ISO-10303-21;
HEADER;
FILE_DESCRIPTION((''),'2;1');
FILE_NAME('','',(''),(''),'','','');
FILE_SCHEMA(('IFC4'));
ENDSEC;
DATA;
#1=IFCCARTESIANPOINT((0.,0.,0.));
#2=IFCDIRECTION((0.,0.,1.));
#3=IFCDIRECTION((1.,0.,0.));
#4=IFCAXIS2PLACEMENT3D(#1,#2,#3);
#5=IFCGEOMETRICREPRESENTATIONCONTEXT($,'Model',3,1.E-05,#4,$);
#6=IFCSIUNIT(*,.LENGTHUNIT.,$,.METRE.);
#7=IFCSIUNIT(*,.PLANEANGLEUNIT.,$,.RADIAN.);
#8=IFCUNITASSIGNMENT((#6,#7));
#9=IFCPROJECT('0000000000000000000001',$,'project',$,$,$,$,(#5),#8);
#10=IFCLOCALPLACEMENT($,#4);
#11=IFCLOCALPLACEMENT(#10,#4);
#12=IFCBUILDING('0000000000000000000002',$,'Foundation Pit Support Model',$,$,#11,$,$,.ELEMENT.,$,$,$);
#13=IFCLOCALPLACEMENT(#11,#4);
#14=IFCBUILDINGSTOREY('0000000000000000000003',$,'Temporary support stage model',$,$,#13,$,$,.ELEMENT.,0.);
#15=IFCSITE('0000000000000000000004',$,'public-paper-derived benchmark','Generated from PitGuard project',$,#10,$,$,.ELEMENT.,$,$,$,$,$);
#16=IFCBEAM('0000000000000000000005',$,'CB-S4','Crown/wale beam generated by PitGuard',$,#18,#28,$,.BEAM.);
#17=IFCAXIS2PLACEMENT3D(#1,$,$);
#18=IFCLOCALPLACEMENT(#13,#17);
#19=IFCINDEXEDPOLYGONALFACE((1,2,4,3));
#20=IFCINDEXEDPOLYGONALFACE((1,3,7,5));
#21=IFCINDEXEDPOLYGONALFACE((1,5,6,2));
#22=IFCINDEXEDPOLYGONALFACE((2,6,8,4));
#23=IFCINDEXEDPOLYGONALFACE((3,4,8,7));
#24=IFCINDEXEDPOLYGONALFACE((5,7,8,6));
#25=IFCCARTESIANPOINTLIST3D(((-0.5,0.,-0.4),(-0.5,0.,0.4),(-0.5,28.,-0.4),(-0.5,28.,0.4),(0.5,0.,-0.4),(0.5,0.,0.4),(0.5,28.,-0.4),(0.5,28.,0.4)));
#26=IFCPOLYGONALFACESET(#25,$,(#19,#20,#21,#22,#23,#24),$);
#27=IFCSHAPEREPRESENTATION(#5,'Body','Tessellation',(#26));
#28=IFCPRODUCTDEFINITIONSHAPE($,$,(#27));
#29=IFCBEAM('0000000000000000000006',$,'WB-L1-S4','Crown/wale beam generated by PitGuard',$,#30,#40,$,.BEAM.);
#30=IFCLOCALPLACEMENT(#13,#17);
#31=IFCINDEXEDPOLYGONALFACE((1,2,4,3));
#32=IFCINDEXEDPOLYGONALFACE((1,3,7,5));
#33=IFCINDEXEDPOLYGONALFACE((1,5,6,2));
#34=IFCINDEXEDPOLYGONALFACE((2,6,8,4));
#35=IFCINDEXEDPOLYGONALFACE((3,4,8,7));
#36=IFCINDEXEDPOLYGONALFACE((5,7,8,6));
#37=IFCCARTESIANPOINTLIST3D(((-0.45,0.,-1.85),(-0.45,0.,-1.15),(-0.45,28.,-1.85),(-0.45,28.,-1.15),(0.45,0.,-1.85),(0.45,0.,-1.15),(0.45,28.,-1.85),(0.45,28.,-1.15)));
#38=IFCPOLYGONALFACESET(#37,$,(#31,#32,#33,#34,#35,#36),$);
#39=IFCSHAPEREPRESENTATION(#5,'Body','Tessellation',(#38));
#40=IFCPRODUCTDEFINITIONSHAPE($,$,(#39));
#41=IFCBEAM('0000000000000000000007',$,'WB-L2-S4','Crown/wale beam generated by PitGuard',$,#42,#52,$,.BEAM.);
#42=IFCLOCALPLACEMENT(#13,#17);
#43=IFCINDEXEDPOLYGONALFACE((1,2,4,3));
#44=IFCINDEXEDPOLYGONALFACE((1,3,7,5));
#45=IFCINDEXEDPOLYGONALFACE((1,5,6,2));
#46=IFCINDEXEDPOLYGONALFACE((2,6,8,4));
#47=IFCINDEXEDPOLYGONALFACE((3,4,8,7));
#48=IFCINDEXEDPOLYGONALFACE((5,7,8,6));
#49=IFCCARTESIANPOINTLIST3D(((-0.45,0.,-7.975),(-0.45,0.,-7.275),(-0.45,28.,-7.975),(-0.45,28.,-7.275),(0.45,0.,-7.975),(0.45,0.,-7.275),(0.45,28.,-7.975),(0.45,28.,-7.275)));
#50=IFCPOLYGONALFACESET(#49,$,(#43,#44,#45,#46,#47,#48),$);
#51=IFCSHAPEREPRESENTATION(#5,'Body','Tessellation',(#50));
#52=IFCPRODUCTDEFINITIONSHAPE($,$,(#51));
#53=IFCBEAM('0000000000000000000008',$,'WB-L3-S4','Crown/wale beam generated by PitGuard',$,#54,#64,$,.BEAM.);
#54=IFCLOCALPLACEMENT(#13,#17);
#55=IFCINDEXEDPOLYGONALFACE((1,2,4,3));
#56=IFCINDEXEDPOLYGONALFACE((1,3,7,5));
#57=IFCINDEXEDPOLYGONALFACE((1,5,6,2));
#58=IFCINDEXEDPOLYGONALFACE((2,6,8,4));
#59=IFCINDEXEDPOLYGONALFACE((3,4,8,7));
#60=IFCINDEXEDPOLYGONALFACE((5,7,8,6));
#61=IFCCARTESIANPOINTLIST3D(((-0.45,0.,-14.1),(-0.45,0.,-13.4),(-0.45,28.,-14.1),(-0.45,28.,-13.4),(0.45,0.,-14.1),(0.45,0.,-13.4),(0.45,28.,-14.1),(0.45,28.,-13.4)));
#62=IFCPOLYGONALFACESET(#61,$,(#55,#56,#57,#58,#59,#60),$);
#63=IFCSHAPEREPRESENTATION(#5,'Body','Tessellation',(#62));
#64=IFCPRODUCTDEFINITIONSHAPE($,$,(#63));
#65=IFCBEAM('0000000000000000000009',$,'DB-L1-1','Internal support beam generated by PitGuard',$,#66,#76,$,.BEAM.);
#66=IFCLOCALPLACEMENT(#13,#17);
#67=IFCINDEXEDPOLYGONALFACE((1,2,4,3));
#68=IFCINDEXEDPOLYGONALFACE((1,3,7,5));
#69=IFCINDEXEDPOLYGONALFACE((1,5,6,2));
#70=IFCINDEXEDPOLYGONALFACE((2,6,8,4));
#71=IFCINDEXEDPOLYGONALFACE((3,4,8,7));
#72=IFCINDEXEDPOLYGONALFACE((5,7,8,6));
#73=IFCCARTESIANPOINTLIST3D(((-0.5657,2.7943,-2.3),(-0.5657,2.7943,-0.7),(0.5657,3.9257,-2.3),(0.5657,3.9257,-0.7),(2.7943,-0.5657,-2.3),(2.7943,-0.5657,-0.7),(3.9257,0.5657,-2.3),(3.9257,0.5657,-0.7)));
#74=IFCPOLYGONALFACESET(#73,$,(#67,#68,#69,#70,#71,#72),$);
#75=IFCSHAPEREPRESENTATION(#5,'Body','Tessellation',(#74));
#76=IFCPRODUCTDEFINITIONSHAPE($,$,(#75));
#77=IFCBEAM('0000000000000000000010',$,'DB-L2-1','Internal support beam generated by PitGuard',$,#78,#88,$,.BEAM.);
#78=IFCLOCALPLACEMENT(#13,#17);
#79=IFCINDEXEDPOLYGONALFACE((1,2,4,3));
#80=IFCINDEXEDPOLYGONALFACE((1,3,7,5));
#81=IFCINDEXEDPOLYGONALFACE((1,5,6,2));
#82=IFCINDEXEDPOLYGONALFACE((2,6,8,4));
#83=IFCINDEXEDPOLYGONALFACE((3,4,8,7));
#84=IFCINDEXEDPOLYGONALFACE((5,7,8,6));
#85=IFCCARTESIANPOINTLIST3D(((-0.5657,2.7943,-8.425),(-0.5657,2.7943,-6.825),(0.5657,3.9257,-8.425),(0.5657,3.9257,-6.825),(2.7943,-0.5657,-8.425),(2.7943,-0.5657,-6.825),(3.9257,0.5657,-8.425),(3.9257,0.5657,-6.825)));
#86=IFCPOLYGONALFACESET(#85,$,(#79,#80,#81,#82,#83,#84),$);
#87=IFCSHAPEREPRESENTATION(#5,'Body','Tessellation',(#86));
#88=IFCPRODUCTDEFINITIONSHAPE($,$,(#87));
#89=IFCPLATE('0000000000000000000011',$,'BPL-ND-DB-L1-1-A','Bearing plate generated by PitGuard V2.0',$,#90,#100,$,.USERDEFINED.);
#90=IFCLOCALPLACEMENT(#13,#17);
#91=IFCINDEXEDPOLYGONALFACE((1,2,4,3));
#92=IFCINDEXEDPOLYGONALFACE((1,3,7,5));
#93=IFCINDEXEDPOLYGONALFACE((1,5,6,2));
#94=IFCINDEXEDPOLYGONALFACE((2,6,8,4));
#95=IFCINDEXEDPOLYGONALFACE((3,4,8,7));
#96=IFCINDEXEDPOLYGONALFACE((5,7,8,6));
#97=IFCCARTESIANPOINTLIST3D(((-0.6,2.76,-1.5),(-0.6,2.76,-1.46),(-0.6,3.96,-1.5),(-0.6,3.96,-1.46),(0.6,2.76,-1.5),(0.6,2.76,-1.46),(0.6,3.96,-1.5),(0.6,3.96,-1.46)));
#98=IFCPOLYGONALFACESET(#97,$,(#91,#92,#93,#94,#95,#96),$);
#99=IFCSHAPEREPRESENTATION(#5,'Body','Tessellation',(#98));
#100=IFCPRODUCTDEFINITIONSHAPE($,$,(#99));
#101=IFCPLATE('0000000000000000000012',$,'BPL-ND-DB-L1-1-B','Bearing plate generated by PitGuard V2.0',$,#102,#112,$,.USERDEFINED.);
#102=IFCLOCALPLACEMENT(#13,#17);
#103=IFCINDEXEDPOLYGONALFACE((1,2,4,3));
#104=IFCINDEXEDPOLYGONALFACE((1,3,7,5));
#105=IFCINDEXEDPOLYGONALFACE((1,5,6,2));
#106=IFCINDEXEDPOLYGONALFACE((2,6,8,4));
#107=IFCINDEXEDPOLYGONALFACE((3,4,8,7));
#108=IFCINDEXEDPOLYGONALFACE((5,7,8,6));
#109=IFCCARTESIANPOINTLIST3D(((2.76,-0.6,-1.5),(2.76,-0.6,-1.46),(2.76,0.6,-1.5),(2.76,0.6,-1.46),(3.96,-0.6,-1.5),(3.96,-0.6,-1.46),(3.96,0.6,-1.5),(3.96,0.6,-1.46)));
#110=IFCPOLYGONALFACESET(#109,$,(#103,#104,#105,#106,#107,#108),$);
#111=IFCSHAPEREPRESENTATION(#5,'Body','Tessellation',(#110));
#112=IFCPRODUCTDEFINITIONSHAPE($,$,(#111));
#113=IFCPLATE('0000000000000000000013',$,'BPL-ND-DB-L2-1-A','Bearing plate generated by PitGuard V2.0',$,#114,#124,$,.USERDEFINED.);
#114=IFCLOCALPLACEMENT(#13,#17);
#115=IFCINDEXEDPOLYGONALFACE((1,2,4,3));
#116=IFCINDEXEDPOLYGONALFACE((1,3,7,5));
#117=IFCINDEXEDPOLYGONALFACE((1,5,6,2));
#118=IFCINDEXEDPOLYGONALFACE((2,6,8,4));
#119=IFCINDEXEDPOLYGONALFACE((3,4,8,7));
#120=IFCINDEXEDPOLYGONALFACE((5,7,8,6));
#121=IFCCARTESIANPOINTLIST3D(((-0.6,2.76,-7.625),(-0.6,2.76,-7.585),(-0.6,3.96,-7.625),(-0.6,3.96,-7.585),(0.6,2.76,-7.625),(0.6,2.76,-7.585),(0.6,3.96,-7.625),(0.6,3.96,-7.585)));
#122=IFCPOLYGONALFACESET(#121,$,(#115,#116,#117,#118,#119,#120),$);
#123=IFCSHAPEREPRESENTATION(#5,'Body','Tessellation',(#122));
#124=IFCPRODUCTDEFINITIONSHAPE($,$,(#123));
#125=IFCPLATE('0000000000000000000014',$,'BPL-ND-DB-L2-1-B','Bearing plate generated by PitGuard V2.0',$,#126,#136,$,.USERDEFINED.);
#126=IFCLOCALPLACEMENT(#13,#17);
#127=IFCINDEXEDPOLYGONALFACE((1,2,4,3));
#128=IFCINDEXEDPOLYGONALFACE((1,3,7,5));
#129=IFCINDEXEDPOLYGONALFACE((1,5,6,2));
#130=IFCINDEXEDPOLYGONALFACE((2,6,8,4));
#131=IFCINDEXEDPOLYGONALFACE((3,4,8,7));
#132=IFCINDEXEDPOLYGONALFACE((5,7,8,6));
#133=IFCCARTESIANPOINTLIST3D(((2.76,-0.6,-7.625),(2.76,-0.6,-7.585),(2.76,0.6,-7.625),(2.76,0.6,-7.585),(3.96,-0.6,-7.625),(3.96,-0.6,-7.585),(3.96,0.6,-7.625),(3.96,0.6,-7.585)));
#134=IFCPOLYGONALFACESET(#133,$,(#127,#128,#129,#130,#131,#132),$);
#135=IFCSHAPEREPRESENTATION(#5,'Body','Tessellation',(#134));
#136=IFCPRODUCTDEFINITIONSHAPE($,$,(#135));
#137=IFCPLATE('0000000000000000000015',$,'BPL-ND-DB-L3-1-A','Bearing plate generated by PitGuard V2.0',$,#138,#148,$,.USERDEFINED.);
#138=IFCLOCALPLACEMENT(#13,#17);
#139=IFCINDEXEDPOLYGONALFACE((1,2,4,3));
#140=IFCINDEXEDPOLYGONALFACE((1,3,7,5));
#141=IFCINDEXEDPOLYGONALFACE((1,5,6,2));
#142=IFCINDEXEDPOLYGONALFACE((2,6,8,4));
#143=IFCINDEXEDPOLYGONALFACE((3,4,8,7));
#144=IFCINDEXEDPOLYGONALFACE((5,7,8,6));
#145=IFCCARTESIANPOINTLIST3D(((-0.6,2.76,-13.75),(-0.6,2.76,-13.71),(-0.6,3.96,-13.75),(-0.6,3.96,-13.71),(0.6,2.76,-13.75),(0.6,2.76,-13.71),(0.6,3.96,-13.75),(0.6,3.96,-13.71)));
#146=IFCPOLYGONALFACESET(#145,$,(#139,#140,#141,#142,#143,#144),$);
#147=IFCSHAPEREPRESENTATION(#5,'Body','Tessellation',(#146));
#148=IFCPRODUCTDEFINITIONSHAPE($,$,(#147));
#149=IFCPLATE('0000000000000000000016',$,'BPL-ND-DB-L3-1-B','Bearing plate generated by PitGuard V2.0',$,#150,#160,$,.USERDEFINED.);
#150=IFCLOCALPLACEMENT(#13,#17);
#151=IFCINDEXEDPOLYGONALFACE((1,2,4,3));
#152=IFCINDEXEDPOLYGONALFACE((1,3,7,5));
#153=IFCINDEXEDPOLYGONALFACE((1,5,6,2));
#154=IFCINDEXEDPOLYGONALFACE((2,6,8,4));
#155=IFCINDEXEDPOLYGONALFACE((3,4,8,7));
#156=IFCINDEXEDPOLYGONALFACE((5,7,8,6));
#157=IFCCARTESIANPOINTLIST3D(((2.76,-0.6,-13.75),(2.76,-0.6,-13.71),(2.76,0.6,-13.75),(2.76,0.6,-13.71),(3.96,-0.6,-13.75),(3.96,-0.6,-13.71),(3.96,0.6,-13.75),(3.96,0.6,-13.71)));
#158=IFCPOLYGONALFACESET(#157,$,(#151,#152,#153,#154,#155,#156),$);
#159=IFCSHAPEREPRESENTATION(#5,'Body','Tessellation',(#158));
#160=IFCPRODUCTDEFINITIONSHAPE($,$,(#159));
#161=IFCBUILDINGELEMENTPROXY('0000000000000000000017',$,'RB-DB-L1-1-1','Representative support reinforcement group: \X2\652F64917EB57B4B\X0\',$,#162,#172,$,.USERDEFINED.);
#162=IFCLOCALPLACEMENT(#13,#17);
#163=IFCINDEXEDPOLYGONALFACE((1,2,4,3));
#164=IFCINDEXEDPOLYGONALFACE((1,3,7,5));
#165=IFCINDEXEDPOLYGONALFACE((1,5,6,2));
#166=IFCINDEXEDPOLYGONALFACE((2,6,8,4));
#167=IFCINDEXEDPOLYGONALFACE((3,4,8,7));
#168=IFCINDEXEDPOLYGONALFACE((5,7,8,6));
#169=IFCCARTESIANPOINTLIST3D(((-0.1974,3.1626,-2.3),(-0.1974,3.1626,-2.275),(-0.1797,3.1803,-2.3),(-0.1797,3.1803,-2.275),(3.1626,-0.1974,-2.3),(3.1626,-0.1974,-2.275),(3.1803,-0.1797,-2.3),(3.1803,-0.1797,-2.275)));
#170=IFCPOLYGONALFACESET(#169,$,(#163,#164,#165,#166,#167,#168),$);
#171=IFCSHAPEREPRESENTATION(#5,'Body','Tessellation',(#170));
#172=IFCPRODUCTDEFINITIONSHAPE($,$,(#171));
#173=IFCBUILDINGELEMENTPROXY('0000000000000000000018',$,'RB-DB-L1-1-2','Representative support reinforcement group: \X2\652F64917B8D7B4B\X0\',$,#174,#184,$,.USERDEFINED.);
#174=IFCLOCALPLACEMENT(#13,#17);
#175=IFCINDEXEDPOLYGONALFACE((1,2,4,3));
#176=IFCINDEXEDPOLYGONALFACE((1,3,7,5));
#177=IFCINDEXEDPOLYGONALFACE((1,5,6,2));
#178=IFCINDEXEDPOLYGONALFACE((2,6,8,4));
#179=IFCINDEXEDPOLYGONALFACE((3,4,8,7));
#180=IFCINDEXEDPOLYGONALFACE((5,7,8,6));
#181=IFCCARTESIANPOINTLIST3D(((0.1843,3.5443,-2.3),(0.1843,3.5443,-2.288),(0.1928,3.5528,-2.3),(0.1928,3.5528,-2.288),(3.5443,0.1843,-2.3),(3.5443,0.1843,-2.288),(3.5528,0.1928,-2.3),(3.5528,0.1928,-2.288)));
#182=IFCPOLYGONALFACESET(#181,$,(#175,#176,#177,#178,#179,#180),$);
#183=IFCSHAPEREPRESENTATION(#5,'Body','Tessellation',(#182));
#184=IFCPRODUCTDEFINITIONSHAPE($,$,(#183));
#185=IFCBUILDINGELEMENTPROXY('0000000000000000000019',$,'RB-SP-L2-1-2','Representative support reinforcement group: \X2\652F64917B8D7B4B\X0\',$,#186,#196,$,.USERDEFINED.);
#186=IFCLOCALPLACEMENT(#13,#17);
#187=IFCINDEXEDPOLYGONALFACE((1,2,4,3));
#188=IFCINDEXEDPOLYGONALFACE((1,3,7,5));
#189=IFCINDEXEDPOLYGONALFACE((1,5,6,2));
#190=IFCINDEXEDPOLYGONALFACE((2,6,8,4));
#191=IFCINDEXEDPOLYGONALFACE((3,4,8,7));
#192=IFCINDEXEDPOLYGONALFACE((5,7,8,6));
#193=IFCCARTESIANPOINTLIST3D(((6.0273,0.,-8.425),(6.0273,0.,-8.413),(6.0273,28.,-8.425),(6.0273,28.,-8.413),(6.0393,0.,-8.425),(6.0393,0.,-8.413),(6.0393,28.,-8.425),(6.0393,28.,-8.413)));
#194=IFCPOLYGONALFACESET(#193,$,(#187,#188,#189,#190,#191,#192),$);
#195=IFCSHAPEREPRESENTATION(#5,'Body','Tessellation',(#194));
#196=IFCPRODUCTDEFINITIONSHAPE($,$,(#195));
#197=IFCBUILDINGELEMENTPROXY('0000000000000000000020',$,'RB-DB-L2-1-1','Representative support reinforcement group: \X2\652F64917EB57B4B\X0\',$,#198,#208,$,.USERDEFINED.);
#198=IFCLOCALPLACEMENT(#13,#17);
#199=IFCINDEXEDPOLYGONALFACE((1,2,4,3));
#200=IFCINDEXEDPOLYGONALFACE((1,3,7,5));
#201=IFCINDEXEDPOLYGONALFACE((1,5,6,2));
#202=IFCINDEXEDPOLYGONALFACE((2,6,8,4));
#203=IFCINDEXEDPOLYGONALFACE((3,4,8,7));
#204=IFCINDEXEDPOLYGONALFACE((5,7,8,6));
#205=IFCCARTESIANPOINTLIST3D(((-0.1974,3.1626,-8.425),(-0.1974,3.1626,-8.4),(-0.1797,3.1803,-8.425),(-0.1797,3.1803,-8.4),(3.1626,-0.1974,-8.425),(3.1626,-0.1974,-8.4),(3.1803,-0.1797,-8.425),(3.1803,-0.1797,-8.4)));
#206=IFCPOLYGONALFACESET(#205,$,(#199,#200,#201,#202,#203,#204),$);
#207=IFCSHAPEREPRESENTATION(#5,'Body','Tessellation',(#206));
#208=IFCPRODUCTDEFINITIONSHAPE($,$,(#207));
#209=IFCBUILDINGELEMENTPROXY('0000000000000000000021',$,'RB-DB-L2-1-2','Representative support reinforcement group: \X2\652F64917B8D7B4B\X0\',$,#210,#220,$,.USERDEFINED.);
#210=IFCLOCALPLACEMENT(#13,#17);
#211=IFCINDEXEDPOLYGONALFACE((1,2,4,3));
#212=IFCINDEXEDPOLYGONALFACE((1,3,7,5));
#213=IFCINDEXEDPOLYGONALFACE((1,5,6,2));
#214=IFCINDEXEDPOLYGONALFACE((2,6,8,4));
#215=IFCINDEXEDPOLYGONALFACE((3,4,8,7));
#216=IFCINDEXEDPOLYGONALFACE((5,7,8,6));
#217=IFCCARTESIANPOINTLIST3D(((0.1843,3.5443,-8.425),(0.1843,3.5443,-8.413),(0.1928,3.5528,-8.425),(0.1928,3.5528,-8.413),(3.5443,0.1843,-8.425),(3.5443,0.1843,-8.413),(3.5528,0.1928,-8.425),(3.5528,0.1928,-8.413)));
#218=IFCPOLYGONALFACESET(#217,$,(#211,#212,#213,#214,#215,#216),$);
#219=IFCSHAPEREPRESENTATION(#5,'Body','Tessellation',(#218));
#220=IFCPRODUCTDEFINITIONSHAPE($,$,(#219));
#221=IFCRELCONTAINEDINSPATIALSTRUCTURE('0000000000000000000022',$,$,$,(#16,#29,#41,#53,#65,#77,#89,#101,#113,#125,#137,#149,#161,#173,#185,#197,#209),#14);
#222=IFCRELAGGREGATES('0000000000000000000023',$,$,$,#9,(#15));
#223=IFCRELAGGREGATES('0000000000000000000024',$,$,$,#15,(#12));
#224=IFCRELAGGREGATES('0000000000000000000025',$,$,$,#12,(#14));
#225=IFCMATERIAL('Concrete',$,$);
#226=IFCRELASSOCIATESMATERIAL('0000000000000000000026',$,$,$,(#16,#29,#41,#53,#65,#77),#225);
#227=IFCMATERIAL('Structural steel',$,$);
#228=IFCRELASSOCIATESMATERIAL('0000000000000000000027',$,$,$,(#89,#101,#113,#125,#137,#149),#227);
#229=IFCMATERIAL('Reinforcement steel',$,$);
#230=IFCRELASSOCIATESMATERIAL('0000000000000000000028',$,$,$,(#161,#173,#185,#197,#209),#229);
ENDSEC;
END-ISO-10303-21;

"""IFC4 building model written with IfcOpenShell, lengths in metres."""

from ifc_helpers import new_model, si_unit, frame, origin_with_axes, origin_2d, place, context, project, spatial, rectangle, extrude, material, element, save


model = new_model("IFC4")

# Units and contexts
model_context = context("Model", 3, precision=1e-05, world=origin_with_axes())
ifc_project = project(units=[si_unit("LENGTHUNIT", "METRE"), si_unit("PLANEANGLEUNIT", "RADIAN")], contexts=[model_context])

# Site, building, storey
site_placement = place(None, origin_with_axes())
site = spatial("IfcSite", under=ifc_project, at=site_placement, Name="public-paper-derived benchmark", Description="Generated from PitGuard project", CompositionType="ELEMENT")
building_placement = place(site_placement, origin_with_axes())
building = spatial("IfcBuilding", under=site, at=building_placement, Name="Foundation Pit Support Model", CompositionType="ELEMENT")
storey_placement = place(building_placement, origin_with_axes())
storey = spatial("IfcBuildingStorey", under=building, at=storey_placement, Name="Temporary support stage model", CompositionType="ELEMENT", Elevation=0.0)

# Beams
ifc_material_1 = material(Name="Concrete")
beam_placement = place(storey_placement, frame((0.0, 14.0, -0.4), z_axis=(0.0, 0.0, 1.0), x_axis=(0.0, -1.0, 0.0)))
element("IfcBeam", 1, at=beam_placement, inside=storey, material=ifc_material_1, Name="CB-S4", Description="Crown/wale beam generated by PitGuard", PredefinedType="BEAM", context=model_context, shape_type="SweptSolid", body=[
    extrude(rectangle(XDim=28.0, YDim=1.0, at=origin_2d()), origin_with_axes(), (0.0, 0.0, 1.0), 0.8),
])
for number, where, z_axis, x_axis, name in (
    (2, (0.0, 14.0, -1.85), (0.0, 0.0, 1.0), (0.0, -1.0, 0.0), "WB-L1-S4"),
    (3, (0.0, 14.0, -7.975), (0.0, 0.0, 1.0), (0.0, -1.0, 0.0), "WB-L2-S4"),
    (4, (0.0, 14.0, -14.1), (0.0, 0.0, 1.0), (0.0, -1.0, 0.0), "WB-L3-S4"),
):
    element("IfcBeam", number, at=place(storey_placement, frame(where, z_axis=z_axis, x_axis=x_axis)), inside=storey, material=ifc_material_1, Name=name, Description="Crown/wale beam generated by PitGuard", PredefinedType="BEAM", context=model_context, shape_type="SweptSolid", body=[
        extrude(rectangle(XDim=28.0, YDim=0.9, at=origin_2d()), origin_with_axes(), (0.0, 0.0, 1.0), 0.7),
    ])
for number, where, z_axis, x_axis, name in (
    (5, (1.68, 1.68, -2.3), (0.0, 0.0, 1.0), (0.707107, -0.707107, 0.0), "DB-L1-1"),
    (6, (1.68, 1.68, -8.425), (0.0, 0.0, 1.0), (0.707107, -0.707107, 0.0), "DB-L2-1"),
):
    element("IfcBeam", number, at=place(storey_placement, frame(where, z_axis=z_axis, x_axis=x_axis)), inside=storey, material=ifc_material_1, Name=name, Description="Internal support beam generated by PitGuard", PredefinedType="BEAM", context=model_context, shape_type="SweptSolid", body=[
        extrude(rectangle(XDim=4.7518, YDim=1.6, at=origin_2d()), origin_with_axes(), (0.0, 0.0, 1.0), 1.6),
    ])

# Plates
ifc_material_2 = material(Name="Structural steel")
for number, where, z_axis, x_axis, name in (
    (7, (0.0, 3.36, -1.5), (0.0, 0.0, 1.0), (1.0, 0.0, 0.0), "BPL-ND-DB-L1-1-A"),
    (8, (3.36, 0.0, -1.5), (0.0, 0.0, 1.0), (1.0, 0.0, 0.0), "BPL-ND-DB-L1-1-B"),
    (9, (0.0, 3.36, -7.625), (0.0, 0.0, 1.0), (1.0, 0.0, 0.0), "BPL-ND-DB-L2-1-A"),
    (10, (3.36, 0.0, -7.625), (0.0, 0.0, 1.0), (1.0, 0.0, 0.0), "BPL-ND-DB-L2-1-B"),
    (11, (0.0, 3.36, -13.75), (0.0, 0.0, 1.0), (1.0, 0.0, 0.0), "BPL-ND-DB-L3-1-A"),
    (12, (3.36, 0.0, -13.75), (0.0, 0.0, 1.0), (1.0, 0.0, 0.0), "BPL-ND-DB-L3-1-B"),
):
    element("IfcPlate", number, at=place(storey_placement, frame(where, z_axis=z_axis, x_axis=x_axis)), inside=storey, material=ifc_material_2, Name=name, Description="Bearing plate generated by PitGuard V2.0", PredefinedType="USERDEFINED", context=model_context, shape_type="SweptSolid", body=[
        extrude(rectangle(XDim=1.2, YDim=1.2, at=origin_2d()), origin_with_axes(), (0.0, 0.0, 1.0), 0.04),
    ])

# Building element proxies
ifc_material_3 = material(Name="Reinforcement steel")
proxy_1_placement = place(storey_placement, frame((1.4914, 1.4914, -2.3), z_axis=(0.0, 0.0, 1.0), x_axis=(0.707107, -0.707107, 0.0)))
element("IfcBuildingElementProxy", 13, at=proxy_1_placement, inside=storey, material=ifc_material_3, Name="RB-DB-L1-1-1", Description="Representative support reinforcement group: 支撑纵筋", PredefinedType="USERDEFINED", context=model_context, shape_type="SweptSolid", body=[
    extrude(rectangle(XDim=4.7518, YDim=0.025, at=origin_2d()), origin_with_axes(), (0.0, 0.0, 1.0), 0.025),
])
proxy_2_placement = place(storey_placement, frame((1.8686, 1.8686, -2.3), z_axis=(0.0, 0.0, 1.0), x_axis=(0.707107, -0.707107, 0.0)))
element("IfcBuildingElementProxy", 14, at=proxy_2_placement, inside=storey, material=ifc_material_3, Name="RB-DB-L1-1-2", Description="Representative support reinforcement group: 支撑箍筋", PredefinedType="USERDEFINED", context=model_context, shape_type="SweptSolid", body=[
    extrude(rectangle(XDim=4.7518, YDim=0.012, at=origin_2d()), origin_with_axes(), (0.0, 0.0, 1.0), 0.012),
])
proxy_3_placement = place(storey_placement, frame((6.0333, 14.0, -8.425), z_axis=(0.0, 0.0, 1.0), x_axis=(0.0, 1.0, 0.0)))
element("IfcBuildingElementProxy", 15, at=proxy_3_placement, inside=storey, material=ifc_material_3, Name="RB-SP-L2-1-2", Description="Representative support reinforcement group: 支撑箍筋", PredefinedType="USERDEFINED", context=model_context, shape_type="SweptSolid", body=[
    extrude(rectangle(XDim=28.0, YDim=0.012, at=origin_2d()), origin_with_axes(), (0.0, 0.0, 1.0), 0.012),
])
proxy_4_placement = place(storey_placement, frame((1.4914, 1.4914, -8.425), z_axis=(0.0, 0.0, 1.0), x_axis=(0.707107, -0.707107, 0.0)))
element("IfcBuildingElementProxy", 16, at=proxy_4_placement, inside=storey, material=ifc_material_3, Name="RB-DB-L2-1-1", Description="Representative support reinforcement group: 支撑纵筋", PredefinedType="USERDEFINED", context=model_context, shape_type="SweptSolid", body=[
    extrude(rectangle(XDim=4.7518, YDim=0.025, at=origin_2d()), origin_with_axes(), (0.0, 0.0, 1.0), 0.025),
])
proxy_5_placement = place(storey_placement, frame((1.8686, 1.8686, -8.425), z_axis=(0.0, 0.0, 1.0), x_axis=(0.707107, -0.707107, 0.0)))
element("IfcBuildingElementProxy", 17, at=proxy_5_placement, inside=storey, material=ifc_material_3, Name="RB-DB-L2-1-2", Description="Representative support reinforcement group: 支撑箍筋", PredefinedType="USERDEFINED", context=model_context, shape_type="SweptSolid", body=[
    extrude(rectangle(XDim=4.7518, YDim=0.012, at=origin_2d()), origin_with_axes(), (0.0, 0.0, 1.0), 0.012),
])

save(model, "model.ifc")
